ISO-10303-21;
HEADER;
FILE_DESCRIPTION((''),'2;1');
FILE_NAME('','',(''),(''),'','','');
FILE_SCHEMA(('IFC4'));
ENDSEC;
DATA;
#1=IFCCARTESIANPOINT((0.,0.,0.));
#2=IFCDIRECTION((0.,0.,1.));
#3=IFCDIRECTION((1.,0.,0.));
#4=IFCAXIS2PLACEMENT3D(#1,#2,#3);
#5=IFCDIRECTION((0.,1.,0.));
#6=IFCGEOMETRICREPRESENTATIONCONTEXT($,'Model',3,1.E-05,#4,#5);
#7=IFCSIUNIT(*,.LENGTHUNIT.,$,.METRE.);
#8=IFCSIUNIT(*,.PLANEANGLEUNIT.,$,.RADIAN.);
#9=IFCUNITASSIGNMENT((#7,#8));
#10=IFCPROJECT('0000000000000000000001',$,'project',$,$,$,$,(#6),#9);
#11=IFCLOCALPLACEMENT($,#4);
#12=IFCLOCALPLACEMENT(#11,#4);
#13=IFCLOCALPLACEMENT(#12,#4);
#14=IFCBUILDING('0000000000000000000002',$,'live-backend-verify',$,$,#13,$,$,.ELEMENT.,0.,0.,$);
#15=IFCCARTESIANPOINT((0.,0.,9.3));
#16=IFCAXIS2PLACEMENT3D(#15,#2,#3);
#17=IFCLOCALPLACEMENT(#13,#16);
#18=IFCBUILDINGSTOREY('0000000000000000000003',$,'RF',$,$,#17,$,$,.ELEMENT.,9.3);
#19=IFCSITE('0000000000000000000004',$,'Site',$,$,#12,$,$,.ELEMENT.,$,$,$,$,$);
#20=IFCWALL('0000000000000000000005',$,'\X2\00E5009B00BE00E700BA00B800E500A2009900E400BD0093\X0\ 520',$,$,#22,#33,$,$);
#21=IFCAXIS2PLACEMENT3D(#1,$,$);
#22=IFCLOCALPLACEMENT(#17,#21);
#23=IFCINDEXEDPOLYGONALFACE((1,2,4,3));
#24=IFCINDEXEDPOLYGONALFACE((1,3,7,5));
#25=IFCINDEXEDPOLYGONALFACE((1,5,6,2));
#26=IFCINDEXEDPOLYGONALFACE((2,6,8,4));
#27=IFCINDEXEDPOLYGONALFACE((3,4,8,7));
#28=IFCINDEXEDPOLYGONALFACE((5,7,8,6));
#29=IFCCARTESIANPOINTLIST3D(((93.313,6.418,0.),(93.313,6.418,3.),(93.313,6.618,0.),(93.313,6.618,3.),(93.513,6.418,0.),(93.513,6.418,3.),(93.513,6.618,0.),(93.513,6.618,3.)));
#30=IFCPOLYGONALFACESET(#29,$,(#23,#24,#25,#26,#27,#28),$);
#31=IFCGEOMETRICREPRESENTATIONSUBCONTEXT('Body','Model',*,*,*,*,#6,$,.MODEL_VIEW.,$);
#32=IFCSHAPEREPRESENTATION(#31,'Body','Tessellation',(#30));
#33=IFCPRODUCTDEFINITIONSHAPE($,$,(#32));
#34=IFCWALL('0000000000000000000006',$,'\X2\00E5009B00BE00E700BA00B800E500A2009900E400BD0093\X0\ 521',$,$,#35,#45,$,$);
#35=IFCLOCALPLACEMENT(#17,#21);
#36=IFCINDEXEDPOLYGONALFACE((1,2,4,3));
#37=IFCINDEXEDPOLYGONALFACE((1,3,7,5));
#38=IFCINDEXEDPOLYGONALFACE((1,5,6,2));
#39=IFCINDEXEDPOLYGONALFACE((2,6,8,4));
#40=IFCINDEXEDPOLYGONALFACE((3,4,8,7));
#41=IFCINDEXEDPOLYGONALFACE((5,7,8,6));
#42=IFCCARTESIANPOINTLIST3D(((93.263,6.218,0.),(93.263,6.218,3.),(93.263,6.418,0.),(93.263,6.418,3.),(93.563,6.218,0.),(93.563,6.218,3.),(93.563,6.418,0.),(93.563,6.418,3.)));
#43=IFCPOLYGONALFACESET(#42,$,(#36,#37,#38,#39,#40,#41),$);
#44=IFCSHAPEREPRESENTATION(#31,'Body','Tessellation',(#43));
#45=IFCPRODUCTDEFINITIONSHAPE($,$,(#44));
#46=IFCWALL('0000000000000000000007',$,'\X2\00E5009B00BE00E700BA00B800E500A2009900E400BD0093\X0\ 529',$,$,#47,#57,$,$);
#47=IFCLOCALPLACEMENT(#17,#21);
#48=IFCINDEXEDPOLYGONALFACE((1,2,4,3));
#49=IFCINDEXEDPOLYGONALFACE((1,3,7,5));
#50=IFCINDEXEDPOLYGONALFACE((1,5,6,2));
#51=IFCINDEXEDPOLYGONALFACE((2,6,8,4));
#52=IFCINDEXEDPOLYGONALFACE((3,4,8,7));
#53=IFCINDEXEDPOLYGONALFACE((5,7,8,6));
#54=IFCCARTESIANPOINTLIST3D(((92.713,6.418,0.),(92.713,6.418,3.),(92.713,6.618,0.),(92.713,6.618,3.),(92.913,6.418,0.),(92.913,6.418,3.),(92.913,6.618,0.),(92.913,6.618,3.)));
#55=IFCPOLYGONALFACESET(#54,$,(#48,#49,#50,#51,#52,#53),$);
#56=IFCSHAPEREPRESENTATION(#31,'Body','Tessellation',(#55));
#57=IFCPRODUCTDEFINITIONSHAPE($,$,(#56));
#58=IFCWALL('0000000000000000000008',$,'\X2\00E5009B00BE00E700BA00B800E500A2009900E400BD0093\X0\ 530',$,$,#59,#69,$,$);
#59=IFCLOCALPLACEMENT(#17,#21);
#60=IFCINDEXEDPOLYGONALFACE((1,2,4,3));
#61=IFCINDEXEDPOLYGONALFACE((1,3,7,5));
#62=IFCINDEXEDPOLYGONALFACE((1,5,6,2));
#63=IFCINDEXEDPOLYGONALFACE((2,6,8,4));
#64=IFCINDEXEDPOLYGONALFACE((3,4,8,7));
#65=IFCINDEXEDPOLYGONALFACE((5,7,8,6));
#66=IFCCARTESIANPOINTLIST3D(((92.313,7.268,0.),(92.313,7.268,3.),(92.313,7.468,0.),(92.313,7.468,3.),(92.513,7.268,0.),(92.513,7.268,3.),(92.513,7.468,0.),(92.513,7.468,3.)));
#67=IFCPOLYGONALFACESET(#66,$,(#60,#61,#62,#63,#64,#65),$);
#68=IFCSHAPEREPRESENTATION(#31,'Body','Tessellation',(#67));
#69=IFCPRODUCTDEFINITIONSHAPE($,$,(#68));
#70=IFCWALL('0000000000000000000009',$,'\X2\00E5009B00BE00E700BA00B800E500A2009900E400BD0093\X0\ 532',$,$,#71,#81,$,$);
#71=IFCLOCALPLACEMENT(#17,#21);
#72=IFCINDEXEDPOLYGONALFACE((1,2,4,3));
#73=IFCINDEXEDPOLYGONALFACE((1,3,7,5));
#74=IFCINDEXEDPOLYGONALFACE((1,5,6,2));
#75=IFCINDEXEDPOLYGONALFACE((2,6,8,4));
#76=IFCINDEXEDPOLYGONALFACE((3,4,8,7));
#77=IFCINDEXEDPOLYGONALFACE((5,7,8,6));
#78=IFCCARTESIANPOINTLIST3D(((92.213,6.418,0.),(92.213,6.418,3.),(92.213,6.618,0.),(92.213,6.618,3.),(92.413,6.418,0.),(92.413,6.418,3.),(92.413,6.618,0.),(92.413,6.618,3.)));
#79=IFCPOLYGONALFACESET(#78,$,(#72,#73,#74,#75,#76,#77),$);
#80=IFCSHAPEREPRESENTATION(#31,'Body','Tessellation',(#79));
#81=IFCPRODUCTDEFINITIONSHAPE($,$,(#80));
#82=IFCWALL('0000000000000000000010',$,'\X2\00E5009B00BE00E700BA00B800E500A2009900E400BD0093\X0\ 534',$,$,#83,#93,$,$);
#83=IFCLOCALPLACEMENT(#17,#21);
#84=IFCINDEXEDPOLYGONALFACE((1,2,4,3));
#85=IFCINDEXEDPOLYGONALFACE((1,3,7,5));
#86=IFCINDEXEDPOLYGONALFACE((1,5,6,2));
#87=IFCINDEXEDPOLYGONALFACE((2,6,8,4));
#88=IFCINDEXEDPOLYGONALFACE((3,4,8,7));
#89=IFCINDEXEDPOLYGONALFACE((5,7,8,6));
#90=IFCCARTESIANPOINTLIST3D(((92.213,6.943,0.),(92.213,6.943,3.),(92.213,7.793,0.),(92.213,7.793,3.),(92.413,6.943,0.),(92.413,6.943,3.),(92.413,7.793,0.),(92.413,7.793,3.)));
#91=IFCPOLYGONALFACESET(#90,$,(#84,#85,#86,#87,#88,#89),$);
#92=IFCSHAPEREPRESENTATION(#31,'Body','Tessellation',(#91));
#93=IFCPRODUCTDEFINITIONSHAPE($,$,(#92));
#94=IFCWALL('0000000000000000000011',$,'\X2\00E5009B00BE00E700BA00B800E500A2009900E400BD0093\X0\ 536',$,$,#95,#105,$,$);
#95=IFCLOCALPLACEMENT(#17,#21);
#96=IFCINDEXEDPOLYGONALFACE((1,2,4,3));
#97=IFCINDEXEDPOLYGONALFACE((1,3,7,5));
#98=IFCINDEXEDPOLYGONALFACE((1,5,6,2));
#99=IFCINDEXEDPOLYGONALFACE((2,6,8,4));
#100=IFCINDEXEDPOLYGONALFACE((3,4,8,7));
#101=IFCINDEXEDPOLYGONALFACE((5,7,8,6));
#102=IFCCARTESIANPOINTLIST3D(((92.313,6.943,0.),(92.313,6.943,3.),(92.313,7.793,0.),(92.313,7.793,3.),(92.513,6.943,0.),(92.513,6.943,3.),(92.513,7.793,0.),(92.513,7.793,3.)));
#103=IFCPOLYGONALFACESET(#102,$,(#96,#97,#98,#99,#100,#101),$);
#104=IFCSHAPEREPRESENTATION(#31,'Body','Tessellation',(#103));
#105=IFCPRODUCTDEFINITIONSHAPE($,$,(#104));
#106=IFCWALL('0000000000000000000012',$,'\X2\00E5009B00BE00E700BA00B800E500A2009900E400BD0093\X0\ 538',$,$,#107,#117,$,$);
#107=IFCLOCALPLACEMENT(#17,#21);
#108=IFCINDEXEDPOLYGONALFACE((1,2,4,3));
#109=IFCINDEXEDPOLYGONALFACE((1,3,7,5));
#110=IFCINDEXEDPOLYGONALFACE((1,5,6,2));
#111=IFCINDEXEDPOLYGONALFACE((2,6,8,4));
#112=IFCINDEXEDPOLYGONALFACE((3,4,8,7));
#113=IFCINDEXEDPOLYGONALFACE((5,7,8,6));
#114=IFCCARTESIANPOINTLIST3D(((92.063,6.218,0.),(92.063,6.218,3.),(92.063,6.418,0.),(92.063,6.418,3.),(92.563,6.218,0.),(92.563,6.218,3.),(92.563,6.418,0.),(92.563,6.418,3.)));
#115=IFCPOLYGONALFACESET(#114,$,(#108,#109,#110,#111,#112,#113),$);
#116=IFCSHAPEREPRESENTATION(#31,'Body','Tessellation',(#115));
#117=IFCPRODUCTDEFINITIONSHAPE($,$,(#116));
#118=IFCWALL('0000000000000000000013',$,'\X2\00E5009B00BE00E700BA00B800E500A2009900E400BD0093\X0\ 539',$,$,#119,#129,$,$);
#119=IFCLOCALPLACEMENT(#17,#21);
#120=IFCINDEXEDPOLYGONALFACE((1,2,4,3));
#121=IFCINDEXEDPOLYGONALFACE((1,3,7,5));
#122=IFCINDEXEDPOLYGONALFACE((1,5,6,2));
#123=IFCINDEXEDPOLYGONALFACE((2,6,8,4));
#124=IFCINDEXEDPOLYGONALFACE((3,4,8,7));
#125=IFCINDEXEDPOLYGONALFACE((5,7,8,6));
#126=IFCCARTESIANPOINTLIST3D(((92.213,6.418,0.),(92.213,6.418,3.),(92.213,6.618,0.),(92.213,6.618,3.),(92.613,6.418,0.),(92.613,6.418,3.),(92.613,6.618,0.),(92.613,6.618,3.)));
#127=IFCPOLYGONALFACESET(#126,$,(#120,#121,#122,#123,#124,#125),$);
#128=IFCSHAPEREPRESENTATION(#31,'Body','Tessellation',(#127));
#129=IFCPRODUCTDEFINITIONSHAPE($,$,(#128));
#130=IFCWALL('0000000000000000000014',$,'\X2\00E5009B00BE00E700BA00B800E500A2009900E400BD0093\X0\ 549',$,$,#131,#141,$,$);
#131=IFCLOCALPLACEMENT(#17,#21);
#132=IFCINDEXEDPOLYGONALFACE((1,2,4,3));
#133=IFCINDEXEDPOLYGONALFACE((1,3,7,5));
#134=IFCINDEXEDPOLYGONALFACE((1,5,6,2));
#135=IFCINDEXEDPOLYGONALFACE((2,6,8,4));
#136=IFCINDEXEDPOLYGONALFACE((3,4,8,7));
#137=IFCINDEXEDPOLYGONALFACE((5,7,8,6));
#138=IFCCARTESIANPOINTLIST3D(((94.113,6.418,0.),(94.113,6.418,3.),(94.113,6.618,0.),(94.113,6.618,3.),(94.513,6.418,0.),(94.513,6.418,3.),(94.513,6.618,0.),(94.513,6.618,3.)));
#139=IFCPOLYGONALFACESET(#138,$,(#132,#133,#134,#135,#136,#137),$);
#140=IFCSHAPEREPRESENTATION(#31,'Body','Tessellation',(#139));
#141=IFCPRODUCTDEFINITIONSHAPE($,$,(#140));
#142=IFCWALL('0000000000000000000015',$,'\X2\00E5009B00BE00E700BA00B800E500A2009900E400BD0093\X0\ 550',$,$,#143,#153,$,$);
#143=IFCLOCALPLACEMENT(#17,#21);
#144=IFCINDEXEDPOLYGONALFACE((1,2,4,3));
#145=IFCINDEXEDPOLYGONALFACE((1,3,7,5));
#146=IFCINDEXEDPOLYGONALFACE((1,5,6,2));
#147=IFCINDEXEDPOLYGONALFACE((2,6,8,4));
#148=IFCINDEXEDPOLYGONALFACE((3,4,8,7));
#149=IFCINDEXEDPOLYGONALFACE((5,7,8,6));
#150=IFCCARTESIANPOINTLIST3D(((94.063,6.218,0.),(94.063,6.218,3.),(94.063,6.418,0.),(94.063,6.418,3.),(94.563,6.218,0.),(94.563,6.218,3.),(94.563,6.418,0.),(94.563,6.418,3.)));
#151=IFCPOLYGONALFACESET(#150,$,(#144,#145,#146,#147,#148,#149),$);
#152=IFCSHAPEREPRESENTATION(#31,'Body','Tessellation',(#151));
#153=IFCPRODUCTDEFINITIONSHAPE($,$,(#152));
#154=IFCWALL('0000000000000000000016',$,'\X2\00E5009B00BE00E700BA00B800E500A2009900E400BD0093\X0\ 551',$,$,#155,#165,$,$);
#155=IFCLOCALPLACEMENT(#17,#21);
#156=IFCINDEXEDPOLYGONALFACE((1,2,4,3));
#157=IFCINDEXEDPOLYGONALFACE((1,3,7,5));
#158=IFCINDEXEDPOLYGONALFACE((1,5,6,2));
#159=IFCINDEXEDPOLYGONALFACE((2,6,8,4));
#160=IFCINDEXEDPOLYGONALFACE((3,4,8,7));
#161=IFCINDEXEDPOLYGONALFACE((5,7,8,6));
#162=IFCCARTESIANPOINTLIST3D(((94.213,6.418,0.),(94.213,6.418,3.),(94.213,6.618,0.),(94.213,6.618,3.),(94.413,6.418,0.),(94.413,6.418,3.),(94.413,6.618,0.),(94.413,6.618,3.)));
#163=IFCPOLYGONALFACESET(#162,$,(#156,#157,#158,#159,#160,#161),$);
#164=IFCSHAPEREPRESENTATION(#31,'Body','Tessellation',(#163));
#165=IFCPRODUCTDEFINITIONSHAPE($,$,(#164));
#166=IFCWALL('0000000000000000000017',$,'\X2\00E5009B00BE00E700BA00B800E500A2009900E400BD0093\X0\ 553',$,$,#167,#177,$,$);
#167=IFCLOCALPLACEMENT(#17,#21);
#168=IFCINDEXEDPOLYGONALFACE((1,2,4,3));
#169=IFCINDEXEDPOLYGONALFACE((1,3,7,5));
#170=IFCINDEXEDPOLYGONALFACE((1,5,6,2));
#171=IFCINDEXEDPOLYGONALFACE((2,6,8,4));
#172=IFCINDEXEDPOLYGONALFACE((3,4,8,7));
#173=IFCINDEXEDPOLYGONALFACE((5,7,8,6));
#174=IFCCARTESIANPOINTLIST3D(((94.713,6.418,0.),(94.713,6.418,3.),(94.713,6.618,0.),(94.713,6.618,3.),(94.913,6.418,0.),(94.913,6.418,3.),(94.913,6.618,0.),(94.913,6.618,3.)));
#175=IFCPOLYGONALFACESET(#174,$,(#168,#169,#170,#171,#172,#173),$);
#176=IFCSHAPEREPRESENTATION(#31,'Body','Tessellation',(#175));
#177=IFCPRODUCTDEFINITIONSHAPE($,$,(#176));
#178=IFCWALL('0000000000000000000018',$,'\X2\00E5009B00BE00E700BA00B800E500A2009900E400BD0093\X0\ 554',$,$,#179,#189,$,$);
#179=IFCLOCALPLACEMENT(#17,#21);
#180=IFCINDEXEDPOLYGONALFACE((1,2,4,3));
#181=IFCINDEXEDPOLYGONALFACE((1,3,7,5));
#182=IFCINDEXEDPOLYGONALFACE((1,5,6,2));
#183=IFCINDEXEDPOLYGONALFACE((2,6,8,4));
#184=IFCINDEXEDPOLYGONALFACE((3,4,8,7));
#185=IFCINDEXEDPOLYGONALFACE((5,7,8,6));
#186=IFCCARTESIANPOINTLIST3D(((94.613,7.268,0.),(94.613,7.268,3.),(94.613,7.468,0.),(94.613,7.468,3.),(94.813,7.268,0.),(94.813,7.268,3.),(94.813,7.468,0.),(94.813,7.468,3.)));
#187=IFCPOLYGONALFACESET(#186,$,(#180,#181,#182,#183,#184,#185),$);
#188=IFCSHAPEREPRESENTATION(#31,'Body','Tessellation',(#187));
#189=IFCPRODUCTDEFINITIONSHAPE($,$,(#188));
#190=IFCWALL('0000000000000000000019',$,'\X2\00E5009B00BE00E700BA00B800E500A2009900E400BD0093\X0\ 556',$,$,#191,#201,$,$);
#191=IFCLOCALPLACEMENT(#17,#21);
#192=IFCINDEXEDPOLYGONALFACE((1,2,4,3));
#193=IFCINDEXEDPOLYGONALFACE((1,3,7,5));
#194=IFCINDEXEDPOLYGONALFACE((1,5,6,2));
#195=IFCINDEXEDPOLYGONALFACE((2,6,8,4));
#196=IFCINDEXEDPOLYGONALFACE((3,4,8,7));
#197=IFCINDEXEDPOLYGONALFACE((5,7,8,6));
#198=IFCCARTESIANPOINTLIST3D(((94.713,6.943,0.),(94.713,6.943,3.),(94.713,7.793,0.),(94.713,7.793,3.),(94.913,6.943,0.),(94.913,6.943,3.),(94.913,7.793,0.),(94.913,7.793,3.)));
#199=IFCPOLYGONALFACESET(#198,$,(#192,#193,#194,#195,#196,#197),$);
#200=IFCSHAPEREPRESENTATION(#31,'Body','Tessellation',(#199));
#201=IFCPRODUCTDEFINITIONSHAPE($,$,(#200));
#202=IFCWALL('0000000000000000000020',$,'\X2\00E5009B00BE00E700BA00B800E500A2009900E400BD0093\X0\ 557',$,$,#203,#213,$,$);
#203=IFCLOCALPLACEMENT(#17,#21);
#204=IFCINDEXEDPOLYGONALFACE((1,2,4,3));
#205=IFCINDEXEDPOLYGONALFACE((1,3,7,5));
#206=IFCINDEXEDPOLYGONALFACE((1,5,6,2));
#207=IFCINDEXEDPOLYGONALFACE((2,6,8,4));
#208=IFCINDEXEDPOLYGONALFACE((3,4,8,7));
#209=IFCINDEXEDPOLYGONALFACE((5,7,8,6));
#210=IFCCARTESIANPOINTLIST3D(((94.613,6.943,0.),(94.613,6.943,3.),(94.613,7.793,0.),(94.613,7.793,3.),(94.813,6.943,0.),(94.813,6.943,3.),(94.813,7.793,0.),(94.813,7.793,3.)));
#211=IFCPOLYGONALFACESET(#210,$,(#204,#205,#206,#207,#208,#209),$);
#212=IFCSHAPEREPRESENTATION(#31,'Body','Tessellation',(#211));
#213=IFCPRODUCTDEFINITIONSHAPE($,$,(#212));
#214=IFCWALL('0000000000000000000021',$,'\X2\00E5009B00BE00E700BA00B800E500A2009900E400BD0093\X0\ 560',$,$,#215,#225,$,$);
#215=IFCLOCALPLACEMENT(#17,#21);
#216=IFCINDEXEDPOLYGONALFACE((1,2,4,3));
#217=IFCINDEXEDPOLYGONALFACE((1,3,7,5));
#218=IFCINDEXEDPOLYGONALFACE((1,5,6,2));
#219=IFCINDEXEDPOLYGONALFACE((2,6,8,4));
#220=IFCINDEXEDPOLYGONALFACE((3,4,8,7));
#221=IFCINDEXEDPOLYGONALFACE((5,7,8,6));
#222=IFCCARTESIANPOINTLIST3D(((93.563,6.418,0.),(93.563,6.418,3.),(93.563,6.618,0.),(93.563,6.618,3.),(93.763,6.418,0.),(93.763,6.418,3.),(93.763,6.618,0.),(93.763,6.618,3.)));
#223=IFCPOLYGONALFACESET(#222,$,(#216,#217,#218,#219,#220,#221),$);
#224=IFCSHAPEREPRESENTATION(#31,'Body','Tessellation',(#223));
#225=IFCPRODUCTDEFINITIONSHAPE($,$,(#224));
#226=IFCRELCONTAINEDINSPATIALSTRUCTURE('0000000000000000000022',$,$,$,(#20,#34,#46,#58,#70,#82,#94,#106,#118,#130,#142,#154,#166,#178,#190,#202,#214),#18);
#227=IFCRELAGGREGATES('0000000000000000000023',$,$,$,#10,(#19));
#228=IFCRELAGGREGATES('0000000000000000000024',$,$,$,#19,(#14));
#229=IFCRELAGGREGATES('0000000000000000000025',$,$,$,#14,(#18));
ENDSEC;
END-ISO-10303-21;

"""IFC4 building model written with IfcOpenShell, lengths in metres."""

from ifc_helpers import new_model, si_unit, direction, frame, frame_2d, origin_with_axes, place, context, subcontext, project, spatial, rectangle, extrude, element, save


model = new_model("IFC4")

# Units and contexts
model_context = context("Model", 3, precision=1e-05, world=origin_with_axes(), true_north=direction((0.0, 1.0, 0.0)))
body_context = subcontext(model_context, "Body", "Model", "MODEL_VIEW")
ifc_project = project(units=[si_unit("LENGTHUNIT", "METRE"), si_unit("PLANEANGLEUNIT", "RADIAN")], contexts=[model_context])

# Site, building, storey
placement = place(None, origin_with_axes())
site_placement = place(placement, origin_with_axes())
site = spatial("IfcSite", under=ifc_project, at=site_placement, Name="Site", CompositionType="ELEMENT")
building_placement = place(site_placement, origin_with_axes())
building = spatial("IfcBuilding", under=site, at=building_placement, Name="live-backend-verify", CompositionType="ELEMENT", ElevationOfRefHeight=0.0, ElevationOfTerrain=0.0)
storey_placement = place(building_placement, frame((0.0, 0.0, 9.3), z_axis=(0.0, 0.0, 1.0), x_axis=(1.0, 0.0, 0.0)))
storey = spatial("IfcBuildingStorey", under=building, at=storey_placement, Name="RF", CompositionType="ELEMENT", Elevation=9.3)

# Walls
wall_1_placement = place(storey_placement, frame((93.413, 6.518, 0.0), z_axis=(0.0, 0.0, 1.0), x_axis=(1.0, 0.0, 0.0)))
element("IfcWall", 1, at=wall_1_placement, inside=storey, Name="å\u009b¾çº¸å¢\u0099ä½\u0093 520", context=body_context, shape_type="SweptSolid", body=[
    extrude(rectangle(XDim=0.2, YDim=0.2, at=frame_2d((0.0, 0.0), x_axis=(1.0, 0.0, 0.0))), frame((0.0, 0.0, 0.0), z_axis=(0.0, 0.0, 1.0)), (0.0, 0.0, 1.0), 3.0),
])
wall_2_placement = place(storey_placement, frame((93.413, 6.318, 0.0), z_axis=(0.0, 0.0, 1.0), x_axis=(1.0, 0.0, 0.0)))
element("IfcWall", 2, at=wall_2_placement, inside=storey, Name="å\u009b¾çº¸å¢\u0099ä½\u0093 521", context=body_context, shape_type="SweptSolid", body=[
    extrude(rectangle(XDim=0.3, YDim=0.2, at=frame_2d((0.0, 0.0), x_axis=(1.0, 0.0, 0.0))), frame((0.0, 0.0, 0.0), z_axis=(0.0, 0.0, 1.0)), (0.0, 0.0, 1.0), 3.0),
])
for number, where, z_axis, x_axis, name in (
    (3, (92.813, 6.518, 0.0), (0.0, 0.0, 1.0), (0.0, -1.0, 0.0), "å\u009b¾çº¸å¢\u0099ä½\u0093 529"),
    (4, (92.413, 7.368, 0.0), (0.0, 0.0, 1.0), (-1.0, 0.0, 0.0), "å\u009b¾çº¸å¢\u0099ä½\u0093 530"),
    (5, (92.313, 6.518, 0.0), (0.0, 0.0, 1.0), (0.0, -1.0, 0.0), "å\u009b¾çº¸å¢\u0099ä½\u0093 532"),
):
    element("IfcWall", number, at=place(storey_placement, frame(where, z_axis=z_axis, x_axis=x_axis)), inside=storey, Name=name, context=body_context, shape_type="SweptSolid", body=[
        extrude(rectangle(XDim=0.2, YDim=0.2, at=frame_2d((0.0, 0.0), x_axis=(1.0, 0.0, 0.0))), frame((0.0, 0.0, 0.0), z_axis=(0.0, 0.0, 1.0)), (0.0, 0.0, 1.0), 3.0),
    ])
for number, where, z_axis, x_axis, name in (
    (6, (92.313, 7.368, 0.0), (0.0, 0.0, 1.0), (0.0, -1.0, 0.0), "å\u009b¾çº¸å¢\u0099ä½\u0093 534"),
    (7, (92.413, 7.368, 0.0), (0.0, 0.0, 1.0), (0.0, -1.0, 0.0), "å\u009b¾çº¸å¢\u0099ä½\u0093 536"),
):
    element("IfcWall", number, at=place(storey_placement, frame(where, z_axis=z_axis, x_axis=x_axis)), inside=storey, Name=name, context=body_context, shape_type="SweptSolid", body=[
        extrude(rectangle(XDim=0.85, YDim=0.2, at=frame_2d((0.0, 0.0), x_axis=(1.0, 0.0, 0.0))), frame((0.0, 0.0, 0.0), z_axis=(0.0, 0.0, 1.0)), (0.0, 0.0, 1.0), 3.0),
    ])
wall_3_placement = place(storey_placement, frame((92.313, 6.318, 0.0), z_axis=(0.0, 0.0, 1.0), x_axis=(1.0, 0.0, 0.0)))
element("IfcWall", 8, at=wall_3_placement, inside=storey, Name="å\u009b¾çº¸å¢\u0099ä½\u0093 538", context=body_context, shape_type="SweptSolid", body=[
    extrude(rectangle(XDim=0.5, YDim=0.2, at=frame_2d((0.0, 0.0), x_axis=(1.0, 0.0, 0.0))), frame((0.0, 0.0, 0.0), z_axis=(0.0, 0.0, 1.0)), (0.0, 0.0, 1.0), 3.0),
])
for number, where, z_axis, x_axis, name in (
    (9, (92.413, 6.518, 0.0), (0.0, 0.0, 1.0), (1.0, 0.0, 0.0), "å\u009b¾çº¸å¢\u0099ä½\u0093 539"),
    (10, (94.313, 6.518, 0.0), (0.0, 0.0, 1.0), (1.0, 0.0, 0.0), "å\u009b¾çº¸å¢\u0099ä½\u0093 549"),
):
    element("IfcWall", number, at=place(storey_placement, frame(where, z_axis=z_axis, x_axis=x_axis)), inside=storey, Name=name, context=body_context, shape_type="SweptSolid", body=[
        extrude(rectangle(XDim=0.4, YDim=0.2, at=frame_2d((0.0, 0.0), x_axis=(1.0, 0.0, 0.0))), frame((0.0, 0.0, 0.0), z_axis=(0.0, 0.0, 1.0)), (0.0, 0.0, 1.0), 3.0),
    ])
wall_4_placement = place(storey_placement, frame((94.313, 6.318, 0.0), z_axis=(0.0, 0.0, 1.0), x_axis=(1.0, 0.0, 0.0)))
element("IfcWall", 11, at=wall_4_placement, inside=storey, Name="å\u009b¾çº¸å¢\u0099ä½\u0093 550", context=body_context, shape_type="SweptSolid", body=[
    extrude(rectangle(XDim=0.5, YDim=0.2, at=frame_2d((0.0, 0.0), x_axis=(1.0, 0.0, 0.0))), frame((0.0, 0.0, 0.0), z_axis=(0.0, 0.0, 1.0)), (0.0, 0.0, 1.0), 3.0),
])
for number, where, z_axis, x_axis, name in (
    (12, (94.313, 6.518, 0.0), (0.0, 0.0, 1.0), (0.0, -1.0, 0.0), "å\u009b¾çº¸å¢\u0099ä½\u0093 551"),
    (13, (94.813, 6.518, 0.0), (0.0, 0.0, 1.0), (0.0, -1.0, 0.0), "å\u009b¾çº¸å¢\u0099ä½\u0093 553"),
    (14, (94.713, 7.368, 0.0), (0.0, 0.0, 1.0), (1.0, 0.0, 0.0), "å\u009b¾çº¸å¢\u0099ä½\u0093 554"),
):
    element("IfcWall", number, at=place(storey_placement, frame(where, z_axis=z_axis, x_axis=x_axis)), inside=storey, Name=name, context=body_context, shape_type="SweptSolid", body=[
        extrude(rectangle(XDim=0.2, YDim=0.2, at=frame_2d((0.0, 0.0), x_axis=(1.0, 0.0, 0.0))), frame((0.0, 0.0, 0.0), z_axis=(0.0, 0.0, 1.0)), (0.0, 0.0, 1.0), 3.0),
    ])
for number, where, z_axis, x_axis, name in (
    (15, (94.813, 7.368, 0.0), (0.0, 0.0, 1.0), (0.0, -1.0, 0.0), "å\u009b¾çº¸å¢\u0099ä½\u0093 556"),
    (16, (94.713, 7.368, 0.0), (0.0, 0.0, 1.0), (0.0, -1.0, 0.0), "å\u009b¾çº¸å¢\u0099ä½\u0093 557"),
):
    element("IfcWall", number, at=place(storey_placement, frame(where, z_axis=z_axis, x_axis=x_axis)), inside=storey, Name=name, context=body_context, shape_type="SweptSolid", body=[
        extrude(rectangle(XDim=0.85, YDim=0.2, at=frame_2d((0.0, 0.0), x_axis=(1.0, 0.0, 0.0))), frame((0.0, 0.0, 0.0), z_axis=(0.0, 0.0, 1.0)), (0.0, 0.0, 1.0), 3.0),
    ])
for number, where, z_axis, x_axis, name in (
    (17, (93.663, 6.518, 0.0), (0.0, 0.0, 1.0), (1.0, 0.0, 0.0), "å\u009b¾çº¸å¢\u0099ä½\u0093 560"),
):
    element("IfcWall", number, at=place(storey_placement, frame(where, z_axis=z_axis, x_axis=x_axis)), inside=storey, Name=name, context=body_context, shape_type="SweptSolid", body=[
        extrude(rectangle(XDim=0.2, YDim=0.2, at=frame_2d((0.0, 0.0), x_axis=(1.0, 0.0, 0.0))), frame((0.0, 0.0, 0.0), z_axis=(0.0, 0.0, 1.0)), (0.0, 0.0, 1.0), 3.0),
    ])

save(model, "model.ifc")
